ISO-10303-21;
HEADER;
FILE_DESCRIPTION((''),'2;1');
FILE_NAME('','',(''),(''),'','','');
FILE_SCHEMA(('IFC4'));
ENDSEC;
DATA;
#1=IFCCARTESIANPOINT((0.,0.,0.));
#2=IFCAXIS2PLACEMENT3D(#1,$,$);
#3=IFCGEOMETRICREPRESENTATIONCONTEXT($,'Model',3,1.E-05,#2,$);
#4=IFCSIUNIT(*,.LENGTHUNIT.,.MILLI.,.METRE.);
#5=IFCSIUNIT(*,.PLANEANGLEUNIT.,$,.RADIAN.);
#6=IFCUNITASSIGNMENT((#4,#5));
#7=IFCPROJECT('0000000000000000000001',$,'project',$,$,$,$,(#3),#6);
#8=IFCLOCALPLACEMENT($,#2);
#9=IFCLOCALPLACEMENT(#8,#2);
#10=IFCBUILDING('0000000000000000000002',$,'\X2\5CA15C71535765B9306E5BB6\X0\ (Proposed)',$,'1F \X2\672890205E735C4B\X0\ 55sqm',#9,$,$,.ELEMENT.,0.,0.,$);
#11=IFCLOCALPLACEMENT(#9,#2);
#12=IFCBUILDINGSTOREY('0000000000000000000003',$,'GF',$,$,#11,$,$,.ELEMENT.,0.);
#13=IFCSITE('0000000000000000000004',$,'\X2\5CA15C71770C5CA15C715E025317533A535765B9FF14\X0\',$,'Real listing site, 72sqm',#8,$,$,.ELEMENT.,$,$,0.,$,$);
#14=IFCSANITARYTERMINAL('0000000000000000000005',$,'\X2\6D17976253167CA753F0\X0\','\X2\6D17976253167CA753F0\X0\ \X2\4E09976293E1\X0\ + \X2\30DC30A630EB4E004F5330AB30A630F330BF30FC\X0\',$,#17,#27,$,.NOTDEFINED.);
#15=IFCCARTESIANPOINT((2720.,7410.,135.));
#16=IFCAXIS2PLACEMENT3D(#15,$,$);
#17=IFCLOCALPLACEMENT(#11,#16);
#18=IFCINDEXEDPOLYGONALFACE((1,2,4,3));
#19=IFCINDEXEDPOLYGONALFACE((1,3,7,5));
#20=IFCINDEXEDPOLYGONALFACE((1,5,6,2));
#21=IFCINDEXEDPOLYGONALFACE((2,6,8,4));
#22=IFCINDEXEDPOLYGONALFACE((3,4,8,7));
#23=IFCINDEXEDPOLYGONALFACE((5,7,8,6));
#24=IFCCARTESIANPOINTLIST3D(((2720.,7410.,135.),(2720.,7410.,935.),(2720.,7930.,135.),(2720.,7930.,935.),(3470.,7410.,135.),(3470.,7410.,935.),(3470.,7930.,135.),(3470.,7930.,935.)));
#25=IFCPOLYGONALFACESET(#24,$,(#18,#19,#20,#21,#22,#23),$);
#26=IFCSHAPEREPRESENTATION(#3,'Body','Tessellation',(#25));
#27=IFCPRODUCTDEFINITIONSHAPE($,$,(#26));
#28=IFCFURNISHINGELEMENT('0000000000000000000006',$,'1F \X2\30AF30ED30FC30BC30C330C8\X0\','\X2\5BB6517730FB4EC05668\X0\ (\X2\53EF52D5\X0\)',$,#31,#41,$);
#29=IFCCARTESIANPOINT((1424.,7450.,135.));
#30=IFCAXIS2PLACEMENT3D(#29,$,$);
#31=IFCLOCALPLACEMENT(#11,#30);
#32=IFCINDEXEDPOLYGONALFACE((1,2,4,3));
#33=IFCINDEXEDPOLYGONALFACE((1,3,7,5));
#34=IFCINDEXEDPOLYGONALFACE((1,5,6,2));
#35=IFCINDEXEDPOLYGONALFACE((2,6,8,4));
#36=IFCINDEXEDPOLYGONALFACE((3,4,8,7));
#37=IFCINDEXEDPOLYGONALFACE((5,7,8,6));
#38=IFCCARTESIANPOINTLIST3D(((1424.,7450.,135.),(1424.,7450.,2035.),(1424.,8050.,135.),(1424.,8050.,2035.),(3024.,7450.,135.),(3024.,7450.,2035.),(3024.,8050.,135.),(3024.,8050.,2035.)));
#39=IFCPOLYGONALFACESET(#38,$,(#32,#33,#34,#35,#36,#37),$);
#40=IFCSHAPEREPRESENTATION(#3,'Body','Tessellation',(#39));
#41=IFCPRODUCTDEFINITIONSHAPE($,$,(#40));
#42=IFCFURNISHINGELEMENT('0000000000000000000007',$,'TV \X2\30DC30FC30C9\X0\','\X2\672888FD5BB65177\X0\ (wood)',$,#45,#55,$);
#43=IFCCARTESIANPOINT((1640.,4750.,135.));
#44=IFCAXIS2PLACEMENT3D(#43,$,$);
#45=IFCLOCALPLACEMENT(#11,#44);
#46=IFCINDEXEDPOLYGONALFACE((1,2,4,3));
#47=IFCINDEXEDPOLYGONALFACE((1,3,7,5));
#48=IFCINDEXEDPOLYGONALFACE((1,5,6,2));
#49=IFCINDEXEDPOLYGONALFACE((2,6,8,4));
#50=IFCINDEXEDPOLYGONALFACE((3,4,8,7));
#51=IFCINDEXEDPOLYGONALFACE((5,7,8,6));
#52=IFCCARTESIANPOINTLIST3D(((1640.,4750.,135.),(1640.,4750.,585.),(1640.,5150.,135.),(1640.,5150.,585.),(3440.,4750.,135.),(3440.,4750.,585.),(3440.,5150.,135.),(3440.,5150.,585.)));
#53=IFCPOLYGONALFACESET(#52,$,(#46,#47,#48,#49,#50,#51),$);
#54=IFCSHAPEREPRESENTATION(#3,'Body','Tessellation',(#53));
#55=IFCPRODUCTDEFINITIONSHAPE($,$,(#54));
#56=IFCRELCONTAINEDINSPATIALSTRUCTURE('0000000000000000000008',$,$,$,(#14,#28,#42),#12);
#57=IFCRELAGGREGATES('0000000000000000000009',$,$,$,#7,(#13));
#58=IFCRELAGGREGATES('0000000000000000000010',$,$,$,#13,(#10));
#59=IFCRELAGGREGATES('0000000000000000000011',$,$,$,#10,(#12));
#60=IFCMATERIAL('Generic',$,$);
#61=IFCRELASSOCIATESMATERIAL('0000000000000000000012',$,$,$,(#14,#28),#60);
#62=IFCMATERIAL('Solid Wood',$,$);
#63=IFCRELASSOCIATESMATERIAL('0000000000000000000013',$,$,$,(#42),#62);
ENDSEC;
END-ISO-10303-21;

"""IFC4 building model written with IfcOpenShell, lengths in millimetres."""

from ifc_helpers import new_model, si_unit, frame, frame_2d, origin, place, context, project, spatial, rectangle, extrude, material, element, save


model = new_model("IFC4")

# Units and contexts
model_context = context("Model", 3, precision=1e-05, world=origin())
ifc_project = project(units=[si_unit("LENGTHUNIT", "METRE", prefix="MILLI"), si_unit("PLANEANGLEUNIT", "RADIAN")], contexts=[model_context])

# Site, building, storey
site_placement = place(None, origin())
site = spatial("IfcSite", under=ifc_project, at=site_placement, Name="岡山県岡山市北区南方４", ObjectType="Real listing site, 72sqm", CompositionType="ELEMENT", RefElevation=0.0)
building_placement = place(site_placement, origin())
building = spatial("IfcBuilding", under=site, at=building_placement, Name="岡山南方の家 (Proposed)", ObjectType="1F 木造平屋 55sqm", CompositionType="ELEMENT", ElevationOfRefHeight=0.0, ElevationOfTerrain=0.0)
storey_placement = place(building_placement, origin())
storey = spatial("IfcBuildingStorey", under=building, at=storey_placement, Name="GF", CompositionType="ELEMENT", Elevation=0.0)

# Shared definitions
ifc_material_1 = material(Name="Solid Wood")

# Shared definitions
ifc_material_2 = material(Name="Generic")

# Sanitary terminal
sanitary_terminal_1_placement = place(storey_placement, frame((2720.0, 7410.0, 135.0)))
element("IfcSanitaryTerminal", 1, at=sanitary_terminal_1_placement, inside=storey, material=ifc_material_2, Name="洗面化粧台", Description="洗面化粧台 三面鏡 + ボウル一体カウンター", PredefinedType="NOTDEFINED", context=model_context, shape_type="SweptSolid", body=[
    extrude(rectangle(XDim=750.0, YDim=520.0, at=frame_2d((375.0, 260.0))), frame((2720.0, 7410.0, 135.0)), (0.0, 0.0, 1.0), 800.0),
])

# Furnishing elements
furnishing_1_placement = place(storey_placement, frame((1424.0, 7450.0, 135.0)))
element("IfcFurnishingElement", 2, at=furnishing_1_placement, inside=storey, material=ifc_material_2, Name="1F クローゼット", Description="家具・什器 (可動)", context=model_context, shape_type="SweptSolid", body=[
    extrude(rectangle(XDim=1600.0, YDim=600.0, at=frame_2d((800.0, 300.0))), frame((1424.0, 7450.0, 135.0)), (0.0, 0.0, 1.0), 1900.0),
])
furnishing_2_placement = place(storey_placement, frame((1640.0, 4750.0, 135.0)))
element("IfcFurnishingElement", 3, at=furnishing_2_placement, inside=storey, material=ifc_material_1, Name="TV ボード", Description="木製家具 (wood)", context=model_context, shape_type="SweptSolid", body=[
    extrude(rectangle(XDim=1800.0, YDim=400.0, at=frame_2d((900.0, 200.0))), frame((1640.0, 4750.0, 135.0)), (0.0, 0.0, 1.0), 450.0),
])

save(model, "model.ifc")
